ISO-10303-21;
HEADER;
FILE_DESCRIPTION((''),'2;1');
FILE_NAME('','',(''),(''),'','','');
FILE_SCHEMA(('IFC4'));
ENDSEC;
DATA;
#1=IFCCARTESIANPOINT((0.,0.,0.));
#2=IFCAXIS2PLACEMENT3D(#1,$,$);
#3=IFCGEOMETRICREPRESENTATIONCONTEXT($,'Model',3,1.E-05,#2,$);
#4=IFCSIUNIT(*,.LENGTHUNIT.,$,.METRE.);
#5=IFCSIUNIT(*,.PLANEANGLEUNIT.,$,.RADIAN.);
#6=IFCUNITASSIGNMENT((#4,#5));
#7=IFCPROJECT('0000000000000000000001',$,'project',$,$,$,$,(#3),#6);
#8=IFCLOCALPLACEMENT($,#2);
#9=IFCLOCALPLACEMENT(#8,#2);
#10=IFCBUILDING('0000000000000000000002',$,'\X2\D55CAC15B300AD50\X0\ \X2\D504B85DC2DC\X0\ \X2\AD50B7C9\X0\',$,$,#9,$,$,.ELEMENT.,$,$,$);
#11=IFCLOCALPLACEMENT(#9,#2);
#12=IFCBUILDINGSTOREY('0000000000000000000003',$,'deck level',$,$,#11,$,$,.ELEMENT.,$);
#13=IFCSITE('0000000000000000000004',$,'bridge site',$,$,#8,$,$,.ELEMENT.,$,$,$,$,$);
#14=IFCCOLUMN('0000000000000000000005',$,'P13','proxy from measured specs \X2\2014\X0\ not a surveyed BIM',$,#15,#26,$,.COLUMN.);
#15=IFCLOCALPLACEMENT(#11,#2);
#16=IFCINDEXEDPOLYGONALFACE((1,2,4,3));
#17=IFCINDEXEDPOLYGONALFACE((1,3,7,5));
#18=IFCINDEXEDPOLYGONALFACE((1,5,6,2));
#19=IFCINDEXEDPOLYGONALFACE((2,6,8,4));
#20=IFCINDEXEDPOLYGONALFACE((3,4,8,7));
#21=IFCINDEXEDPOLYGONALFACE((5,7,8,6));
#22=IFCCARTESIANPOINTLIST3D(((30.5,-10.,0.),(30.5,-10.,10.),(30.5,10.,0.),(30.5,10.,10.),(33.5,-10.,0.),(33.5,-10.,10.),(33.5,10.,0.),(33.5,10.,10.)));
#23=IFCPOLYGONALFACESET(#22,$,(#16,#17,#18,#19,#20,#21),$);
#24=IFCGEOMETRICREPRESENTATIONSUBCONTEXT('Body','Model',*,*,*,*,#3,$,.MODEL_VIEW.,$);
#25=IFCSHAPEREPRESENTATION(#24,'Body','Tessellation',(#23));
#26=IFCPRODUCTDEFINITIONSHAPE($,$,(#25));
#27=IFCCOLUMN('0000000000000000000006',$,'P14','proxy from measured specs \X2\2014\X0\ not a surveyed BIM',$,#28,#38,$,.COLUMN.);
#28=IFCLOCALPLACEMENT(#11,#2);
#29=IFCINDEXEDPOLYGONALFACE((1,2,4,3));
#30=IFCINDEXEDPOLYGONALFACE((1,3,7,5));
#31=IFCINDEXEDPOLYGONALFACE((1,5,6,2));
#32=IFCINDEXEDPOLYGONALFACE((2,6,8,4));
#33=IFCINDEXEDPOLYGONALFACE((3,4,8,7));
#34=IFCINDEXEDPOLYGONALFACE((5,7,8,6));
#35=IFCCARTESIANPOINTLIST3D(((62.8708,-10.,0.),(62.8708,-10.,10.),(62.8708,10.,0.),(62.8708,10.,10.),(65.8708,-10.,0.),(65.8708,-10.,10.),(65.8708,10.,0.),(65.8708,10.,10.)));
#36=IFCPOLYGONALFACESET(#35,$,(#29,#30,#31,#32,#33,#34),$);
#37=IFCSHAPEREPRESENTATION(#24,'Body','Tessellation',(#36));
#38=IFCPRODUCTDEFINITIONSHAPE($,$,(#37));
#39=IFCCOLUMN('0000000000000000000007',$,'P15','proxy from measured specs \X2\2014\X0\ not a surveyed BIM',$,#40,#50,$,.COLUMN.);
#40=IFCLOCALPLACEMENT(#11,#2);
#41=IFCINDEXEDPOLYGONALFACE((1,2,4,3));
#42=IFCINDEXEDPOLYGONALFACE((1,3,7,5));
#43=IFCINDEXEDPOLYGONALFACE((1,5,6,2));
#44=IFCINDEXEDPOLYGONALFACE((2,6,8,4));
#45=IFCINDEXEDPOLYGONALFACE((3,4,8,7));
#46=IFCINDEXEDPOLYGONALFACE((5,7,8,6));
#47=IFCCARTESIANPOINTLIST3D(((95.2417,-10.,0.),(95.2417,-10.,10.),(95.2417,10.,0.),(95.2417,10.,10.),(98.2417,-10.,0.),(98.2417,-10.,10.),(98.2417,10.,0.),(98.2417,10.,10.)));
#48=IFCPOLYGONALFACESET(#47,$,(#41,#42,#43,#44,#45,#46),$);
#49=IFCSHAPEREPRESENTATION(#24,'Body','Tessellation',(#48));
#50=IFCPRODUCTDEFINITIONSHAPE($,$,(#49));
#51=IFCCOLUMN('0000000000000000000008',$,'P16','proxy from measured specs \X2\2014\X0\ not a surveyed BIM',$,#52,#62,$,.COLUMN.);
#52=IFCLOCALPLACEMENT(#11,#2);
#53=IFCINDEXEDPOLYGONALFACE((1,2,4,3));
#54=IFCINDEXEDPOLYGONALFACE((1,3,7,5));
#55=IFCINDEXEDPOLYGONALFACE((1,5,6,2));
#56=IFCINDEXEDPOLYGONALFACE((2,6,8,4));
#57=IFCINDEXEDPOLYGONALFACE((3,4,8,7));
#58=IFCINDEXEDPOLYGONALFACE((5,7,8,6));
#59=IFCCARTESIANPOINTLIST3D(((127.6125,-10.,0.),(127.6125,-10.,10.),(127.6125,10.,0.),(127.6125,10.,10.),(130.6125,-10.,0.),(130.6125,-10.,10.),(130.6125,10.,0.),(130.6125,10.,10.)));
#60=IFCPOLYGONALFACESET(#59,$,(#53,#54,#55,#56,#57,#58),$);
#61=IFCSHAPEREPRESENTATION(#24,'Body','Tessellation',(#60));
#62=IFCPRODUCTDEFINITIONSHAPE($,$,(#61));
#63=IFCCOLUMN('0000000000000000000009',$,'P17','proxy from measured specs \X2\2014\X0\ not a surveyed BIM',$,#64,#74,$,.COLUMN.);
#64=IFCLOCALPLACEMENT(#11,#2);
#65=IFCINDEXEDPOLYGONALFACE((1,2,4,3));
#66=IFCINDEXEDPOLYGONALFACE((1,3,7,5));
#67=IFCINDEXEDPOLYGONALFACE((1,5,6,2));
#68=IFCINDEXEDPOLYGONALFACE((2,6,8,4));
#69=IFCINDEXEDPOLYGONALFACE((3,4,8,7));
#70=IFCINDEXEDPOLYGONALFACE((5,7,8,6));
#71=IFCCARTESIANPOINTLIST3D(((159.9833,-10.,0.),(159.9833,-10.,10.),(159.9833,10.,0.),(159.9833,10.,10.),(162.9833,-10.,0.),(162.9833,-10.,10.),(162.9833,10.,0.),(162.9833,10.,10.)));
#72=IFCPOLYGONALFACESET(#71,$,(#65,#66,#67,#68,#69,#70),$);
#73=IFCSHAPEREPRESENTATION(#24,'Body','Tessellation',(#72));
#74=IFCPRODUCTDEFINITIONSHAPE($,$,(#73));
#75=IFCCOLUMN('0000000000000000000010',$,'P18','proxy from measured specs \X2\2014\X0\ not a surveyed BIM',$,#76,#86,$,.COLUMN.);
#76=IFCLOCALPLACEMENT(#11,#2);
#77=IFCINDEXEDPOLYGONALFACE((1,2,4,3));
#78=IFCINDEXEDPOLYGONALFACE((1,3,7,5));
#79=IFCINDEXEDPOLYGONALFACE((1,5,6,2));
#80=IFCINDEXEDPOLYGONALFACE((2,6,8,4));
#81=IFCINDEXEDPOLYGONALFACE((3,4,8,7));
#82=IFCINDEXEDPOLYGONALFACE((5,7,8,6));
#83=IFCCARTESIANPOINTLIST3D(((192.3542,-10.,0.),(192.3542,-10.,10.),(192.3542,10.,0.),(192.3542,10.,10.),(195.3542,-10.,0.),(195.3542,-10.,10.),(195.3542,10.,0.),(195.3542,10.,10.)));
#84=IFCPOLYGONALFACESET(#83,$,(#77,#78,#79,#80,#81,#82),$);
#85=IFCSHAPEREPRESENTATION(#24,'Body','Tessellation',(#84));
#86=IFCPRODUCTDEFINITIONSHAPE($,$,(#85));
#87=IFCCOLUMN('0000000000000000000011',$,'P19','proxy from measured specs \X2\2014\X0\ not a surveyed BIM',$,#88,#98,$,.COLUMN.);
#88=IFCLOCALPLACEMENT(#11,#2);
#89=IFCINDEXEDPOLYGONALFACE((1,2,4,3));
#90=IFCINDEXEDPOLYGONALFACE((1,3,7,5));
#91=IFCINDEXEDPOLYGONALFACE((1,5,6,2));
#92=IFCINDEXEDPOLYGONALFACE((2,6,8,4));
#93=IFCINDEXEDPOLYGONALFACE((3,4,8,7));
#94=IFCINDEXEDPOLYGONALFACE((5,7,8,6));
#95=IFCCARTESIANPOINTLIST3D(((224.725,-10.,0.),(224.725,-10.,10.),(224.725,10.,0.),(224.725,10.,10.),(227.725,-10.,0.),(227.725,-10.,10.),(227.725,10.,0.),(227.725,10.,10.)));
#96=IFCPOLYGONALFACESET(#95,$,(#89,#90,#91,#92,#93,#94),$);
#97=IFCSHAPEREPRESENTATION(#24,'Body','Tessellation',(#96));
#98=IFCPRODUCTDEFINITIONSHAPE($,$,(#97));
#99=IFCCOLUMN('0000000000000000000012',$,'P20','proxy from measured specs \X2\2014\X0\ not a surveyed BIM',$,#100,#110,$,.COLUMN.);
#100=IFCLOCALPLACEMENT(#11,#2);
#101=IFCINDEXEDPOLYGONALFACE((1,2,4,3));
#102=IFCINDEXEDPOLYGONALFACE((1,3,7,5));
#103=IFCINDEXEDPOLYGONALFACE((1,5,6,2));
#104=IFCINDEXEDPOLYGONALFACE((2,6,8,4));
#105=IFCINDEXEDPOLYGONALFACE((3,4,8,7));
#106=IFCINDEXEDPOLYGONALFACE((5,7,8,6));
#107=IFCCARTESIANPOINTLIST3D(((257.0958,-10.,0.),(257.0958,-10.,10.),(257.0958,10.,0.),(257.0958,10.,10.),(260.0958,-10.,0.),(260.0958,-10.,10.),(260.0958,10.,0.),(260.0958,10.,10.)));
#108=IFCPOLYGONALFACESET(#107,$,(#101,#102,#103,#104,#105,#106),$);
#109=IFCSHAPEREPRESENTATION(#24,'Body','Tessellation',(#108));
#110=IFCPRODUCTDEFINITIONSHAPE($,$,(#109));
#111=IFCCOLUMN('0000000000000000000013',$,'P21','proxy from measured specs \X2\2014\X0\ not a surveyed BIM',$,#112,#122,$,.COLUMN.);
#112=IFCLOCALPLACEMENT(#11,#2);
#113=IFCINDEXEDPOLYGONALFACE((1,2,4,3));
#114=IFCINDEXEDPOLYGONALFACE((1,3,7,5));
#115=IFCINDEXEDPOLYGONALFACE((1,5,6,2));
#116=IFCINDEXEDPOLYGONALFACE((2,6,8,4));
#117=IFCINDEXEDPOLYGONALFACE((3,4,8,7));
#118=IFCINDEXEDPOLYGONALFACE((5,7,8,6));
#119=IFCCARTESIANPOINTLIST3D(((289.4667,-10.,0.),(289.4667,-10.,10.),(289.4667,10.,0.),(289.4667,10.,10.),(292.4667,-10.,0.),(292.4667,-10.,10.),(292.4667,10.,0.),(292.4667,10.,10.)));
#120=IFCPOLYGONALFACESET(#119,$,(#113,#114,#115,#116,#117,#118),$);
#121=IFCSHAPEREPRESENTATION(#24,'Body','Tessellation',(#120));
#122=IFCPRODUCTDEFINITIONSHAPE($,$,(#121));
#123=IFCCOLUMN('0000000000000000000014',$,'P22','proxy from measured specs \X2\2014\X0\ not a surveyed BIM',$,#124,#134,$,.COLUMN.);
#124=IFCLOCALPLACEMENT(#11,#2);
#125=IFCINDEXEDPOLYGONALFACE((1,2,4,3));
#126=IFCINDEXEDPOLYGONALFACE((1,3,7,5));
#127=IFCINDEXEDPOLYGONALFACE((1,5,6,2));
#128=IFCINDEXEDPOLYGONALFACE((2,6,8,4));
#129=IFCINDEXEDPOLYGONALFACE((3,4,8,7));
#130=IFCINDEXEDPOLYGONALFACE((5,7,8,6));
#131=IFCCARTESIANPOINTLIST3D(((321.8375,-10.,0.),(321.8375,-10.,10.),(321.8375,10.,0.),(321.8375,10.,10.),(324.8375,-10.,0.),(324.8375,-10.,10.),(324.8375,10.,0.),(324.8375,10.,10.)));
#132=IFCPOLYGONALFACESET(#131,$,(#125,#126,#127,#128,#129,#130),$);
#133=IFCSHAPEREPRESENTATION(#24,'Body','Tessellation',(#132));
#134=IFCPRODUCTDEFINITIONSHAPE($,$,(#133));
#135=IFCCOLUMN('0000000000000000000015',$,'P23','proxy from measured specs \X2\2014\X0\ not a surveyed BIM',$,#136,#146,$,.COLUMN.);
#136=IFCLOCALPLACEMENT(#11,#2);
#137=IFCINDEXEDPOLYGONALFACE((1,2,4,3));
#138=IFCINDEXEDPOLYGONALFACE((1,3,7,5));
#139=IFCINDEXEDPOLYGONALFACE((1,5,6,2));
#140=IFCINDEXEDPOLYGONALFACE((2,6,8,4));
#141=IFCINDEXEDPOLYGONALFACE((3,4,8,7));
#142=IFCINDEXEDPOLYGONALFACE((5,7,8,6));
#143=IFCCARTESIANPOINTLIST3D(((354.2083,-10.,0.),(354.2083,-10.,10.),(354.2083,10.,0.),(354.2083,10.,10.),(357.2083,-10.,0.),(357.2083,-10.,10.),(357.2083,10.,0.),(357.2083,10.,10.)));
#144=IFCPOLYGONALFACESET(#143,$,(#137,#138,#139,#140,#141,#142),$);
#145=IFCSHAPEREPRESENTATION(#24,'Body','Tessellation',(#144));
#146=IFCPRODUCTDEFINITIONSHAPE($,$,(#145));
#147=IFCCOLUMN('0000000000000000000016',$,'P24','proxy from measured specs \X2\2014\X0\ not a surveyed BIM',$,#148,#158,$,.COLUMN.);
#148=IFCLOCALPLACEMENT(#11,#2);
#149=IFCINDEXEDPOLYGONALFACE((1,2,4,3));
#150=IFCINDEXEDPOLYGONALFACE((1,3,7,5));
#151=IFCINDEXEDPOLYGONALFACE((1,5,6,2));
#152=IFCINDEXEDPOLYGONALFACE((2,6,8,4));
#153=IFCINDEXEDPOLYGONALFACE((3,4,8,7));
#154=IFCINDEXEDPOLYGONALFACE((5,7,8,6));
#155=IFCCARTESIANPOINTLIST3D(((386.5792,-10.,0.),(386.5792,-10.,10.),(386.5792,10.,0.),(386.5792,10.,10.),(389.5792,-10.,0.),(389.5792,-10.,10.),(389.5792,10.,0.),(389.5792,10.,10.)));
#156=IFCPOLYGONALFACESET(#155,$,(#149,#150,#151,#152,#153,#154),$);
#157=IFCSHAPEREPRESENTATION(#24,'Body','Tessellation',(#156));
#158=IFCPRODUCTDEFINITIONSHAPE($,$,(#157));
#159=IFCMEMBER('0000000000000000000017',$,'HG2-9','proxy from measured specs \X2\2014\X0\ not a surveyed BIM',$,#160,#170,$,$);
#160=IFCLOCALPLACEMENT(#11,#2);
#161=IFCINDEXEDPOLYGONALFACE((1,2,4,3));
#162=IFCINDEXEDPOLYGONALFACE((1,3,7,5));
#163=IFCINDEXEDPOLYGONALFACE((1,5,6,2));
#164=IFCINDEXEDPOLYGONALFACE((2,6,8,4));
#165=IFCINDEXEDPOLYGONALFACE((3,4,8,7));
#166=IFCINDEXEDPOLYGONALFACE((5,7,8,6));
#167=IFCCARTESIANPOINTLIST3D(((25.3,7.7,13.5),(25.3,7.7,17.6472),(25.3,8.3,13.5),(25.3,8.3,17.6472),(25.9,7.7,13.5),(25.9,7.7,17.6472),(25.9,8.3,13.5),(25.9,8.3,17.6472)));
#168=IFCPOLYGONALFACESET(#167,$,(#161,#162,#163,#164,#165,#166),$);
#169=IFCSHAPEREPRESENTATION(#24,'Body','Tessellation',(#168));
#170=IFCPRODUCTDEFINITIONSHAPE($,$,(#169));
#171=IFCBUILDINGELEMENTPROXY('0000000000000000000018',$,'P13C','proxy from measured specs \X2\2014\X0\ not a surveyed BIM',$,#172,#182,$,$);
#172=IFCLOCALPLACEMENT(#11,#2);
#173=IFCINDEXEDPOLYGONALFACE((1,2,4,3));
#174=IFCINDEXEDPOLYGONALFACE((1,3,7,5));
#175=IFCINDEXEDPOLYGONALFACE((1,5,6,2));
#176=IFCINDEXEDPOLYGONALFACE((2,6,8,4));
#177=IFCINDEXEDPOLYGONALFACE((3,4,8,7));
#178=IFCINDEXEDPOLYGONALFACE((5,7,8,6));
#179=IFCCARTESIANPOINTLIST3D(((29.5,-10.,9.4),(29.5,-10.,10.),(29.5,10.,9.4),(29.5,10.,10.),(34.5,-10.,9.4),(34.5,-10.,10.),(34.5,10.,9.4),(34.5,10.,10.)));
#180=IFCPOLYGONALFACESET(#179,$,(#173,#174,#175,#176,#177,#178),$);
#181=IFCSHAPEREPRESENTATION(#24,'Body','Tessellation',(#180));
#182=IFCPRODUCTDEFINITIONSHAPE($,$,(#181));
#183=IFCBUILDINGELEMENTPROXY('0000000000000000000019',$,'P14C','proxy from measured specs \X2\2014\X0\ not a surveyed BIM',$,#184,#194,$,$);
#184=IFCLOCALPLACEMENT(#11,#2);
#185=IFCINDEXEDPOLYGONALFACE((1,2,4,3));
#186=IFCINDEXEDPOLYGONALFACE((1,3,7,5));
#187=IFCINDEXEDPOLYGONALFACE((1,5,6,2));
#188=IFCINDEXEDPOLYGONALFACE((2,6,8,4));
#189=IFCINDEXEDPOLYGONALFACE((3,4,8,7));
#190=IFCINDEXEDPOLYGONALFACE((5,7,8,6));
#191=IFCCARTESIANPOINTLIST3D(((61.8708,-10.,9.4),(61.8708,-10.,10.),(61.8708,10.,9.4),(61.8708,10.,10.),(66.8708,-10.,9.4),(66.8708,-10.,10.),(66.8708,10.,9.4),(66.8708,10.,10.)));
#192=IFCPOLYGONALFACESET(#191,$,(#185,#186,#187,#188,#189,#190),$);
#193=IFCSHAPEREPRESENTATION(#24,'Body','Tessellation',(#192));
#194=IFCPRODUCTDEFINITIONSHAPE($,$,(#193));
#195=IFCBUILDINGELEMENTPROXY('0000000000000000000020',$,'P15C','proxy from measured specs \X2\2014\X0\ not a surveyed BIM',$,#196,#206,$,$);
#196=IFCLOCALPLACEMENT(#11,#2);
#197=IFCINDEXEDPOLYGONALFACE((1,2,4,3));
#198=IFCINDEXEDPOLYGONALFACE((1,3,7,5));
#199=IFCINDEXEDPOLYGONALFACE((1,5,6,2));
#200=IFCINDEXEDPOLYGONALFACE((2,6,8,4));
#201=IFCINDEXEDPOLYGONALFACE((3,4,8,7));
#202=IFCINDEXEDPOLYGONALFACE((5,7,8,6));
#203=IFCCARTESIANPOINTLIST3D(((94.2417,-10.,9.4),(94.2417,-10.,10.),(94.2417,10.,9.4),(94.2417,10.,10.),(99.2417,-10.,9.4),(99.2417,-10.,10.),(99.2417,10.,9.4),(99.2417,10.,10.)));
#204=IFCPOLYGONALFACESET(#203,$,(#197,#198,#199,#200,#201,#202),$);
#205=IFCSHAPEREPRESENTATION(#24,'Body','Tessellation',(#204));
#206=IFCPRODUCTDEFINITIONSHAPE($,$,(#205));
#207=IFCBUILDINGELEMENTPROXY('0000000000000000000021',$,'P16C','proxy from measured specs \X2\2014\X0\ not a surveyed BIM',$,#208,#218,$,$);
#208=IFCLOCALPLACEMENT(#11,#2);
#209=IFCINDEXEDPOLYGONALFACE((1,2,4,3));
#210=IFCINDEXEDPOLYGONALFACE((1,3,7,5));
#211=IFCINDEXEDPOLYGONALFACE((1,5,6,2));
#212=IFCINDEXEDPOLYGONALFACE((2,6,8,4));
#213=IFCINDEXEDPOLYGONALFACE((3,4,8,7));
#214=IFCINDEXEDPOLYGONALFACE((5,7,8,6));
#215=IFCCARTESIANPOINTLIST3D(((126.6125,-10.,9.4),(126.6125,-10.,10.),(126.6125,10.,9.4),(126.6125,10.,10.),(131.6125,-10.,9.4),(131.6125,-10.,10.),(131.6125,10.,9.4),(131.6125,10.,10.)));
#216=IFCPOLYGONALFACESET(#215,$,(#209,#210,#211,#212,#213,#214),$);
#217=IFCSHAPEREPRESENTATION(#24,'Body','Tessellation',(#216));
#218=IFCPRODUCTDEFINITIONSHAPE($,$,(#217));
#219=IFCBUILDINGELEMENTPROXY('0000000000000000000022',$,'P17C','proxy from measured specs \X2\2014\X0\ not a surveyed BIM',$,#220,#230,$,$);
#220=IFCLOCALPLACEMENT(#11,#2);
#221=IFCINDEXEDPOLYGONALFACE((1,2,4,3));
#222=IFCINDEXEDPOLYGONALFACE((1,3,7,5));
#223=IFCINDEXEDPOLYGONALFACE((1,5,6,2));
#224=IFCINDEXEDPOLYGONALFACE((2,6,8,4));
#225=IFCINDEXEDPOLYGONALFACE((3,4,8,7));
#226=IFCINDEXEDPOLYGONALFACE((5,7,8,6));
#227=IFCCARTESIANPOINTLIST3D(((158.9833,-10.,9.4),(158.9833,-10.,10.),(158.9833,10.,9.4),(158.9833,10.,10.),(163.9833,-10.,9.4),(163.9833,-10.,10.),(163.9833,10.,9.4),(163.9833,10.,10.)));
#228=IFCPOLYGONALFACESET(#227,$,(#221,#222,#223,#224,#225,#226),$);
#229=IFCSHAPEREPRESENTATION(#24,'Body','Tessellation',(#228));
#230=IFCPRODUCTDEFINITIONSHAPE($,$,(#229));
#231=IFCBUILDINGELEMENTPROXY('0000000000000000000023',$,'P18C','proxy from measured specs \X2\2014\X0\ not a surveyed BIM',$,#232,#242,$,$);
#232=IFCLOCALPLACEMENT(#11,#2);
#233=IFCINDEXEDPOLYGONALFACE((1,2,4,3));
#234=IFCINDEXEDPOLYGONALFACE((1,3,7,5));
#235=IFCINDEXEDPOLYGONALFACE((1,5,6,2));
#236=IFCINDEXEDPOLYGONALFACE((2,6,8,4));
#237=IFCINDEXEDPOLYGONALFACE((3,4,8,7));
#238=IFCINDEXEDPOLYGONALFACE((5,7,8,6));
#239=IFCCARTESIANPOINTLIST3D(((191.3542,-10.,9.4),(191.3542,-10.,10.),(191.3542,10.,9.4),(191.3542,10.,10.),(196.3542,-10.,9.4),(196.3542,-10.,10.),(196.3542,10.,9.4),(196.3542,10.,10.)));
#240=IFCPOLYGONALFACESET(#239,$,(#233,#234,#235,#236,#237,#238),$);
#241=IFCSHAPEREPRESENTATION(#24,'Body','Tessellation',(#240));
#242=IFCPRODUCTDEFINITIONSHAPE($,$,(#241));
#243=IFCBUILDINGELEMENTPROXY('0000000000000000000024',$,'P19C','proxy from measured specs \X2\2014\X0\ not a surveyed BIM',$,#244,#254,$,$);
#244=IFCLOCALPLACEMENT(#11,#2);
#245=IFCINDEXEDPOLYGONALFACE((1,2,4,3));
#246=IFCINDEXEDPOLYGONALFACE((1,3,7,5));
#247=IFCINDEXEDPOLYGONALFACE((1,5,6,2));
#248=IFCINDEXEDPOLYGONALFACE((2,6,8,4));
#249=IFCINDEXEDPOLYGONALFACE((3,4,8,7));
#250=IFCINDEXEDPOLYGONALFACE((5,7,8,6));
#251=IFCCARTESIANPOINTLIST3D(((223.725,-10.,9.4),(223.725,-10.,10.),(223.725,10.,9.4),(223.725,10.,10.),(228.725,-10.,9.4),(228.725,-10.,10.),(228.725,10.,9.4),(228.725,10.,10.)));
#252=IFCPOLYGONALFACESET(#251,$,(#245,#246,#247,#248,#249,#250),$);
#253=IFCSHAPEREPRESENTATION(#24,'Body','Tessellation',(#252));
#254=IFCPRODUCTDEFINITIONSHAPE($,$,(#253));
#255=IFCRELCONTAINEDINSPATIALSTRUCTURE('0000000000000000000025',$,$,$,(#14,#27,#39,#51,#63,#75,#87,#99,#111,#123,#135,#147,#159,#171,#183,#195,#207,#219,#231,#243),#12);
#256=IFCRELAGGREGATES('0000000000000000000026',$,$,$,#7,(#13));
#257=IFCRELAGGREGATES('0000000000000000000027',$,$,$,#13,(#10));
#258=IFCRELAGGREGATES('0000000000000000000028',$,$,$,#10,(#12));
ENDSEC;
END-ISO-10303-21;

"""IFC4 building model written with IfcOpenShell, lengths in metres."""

from ifc_helpers import new_model, si_unit, frame, origin, origin_2d, place, context, subcontext, project, spatial, rectangle, extrude, element, save


model = new_model("IFC4")

# Units and contexts
model_context = context("Model", 3, precision=1e-05, world=origin())
body_context = subcontext(model_context, "Body", "Model", "MODEL_VIEW")
ifc_project = project(units=[si_unit("LENGTHUNIT", "METRE"), si_unit("PLANEANGLEUNIT", "RADIAN")], contexts=[model_context])

# Site, building, storey
site_placement = place(None, origin())
site = spatial("IfcSite", under=ifc_project, at=site_placement, Name="bridge site", CompositionType="ELEMENT")
building_placement = place(site_placement, origin())
building = spatial("IfcBuilding", under=site, at=building_placement, Name="한강대교 프록시 교량", CompositionType="ELEMENT")
storey_placement = place(building_placement, origin())
storey = spatial("IfcBuildingStorey", under=building, at=storey_placement, Name="deck level", CompositionType="ELEMENT")

# Columns
for number, where, name in (
    (1, (32.0, 0.0, 0.0), "P13"),
    (2, (64.3708, 0.0, 0.0), "P14"),
    (3, (96.7417, 0.0, 0.0), "P15"),
    (4, (129.1125, 0.0, 0.0), "P16"),
    (5, (161.4833, 0.0, 0.0), "P17"),
    (6, (193.8542, 0.0, 0.0), "P18"),
    (7, (226.225, 0.0, 0.0), "P19"),
    (8, (258.5958, 0.0, 0.0), "P20"),
    (9, (290.9667, 0.0, 0.0), "P21"),
    (10, (323.3375, 0.0, 0.0), "P22"),
    (11, (355.7083, 0.0, 0.0), "P23"),
    (12, (388.0792, 0.0, 0.0), "P24"),
):
    element("IfcColumn", number, at=place(storey_placement, frame(where)), inside=storey, Name=name, Description="proxy from measured specs — not a surveyed BIM", PredefinedType="COLUMN", context=body_context, shape_type="SweptSolid", body=[
        extrude(rectangle(XDim=3.0, YDim=20.0, at=origin_2d()), origin(), (0.0, 0.0, 1.0), 10.0),
    ])

# Member
member_placement = place(storey_placement, frame((25.6, 8.0, 13.5)))
element("IfcMember", 13, at=member_placement, inside=storey, Name="HG2-9", Description="proxy from measured specs — not a surveyed BIM", context=body_context, shape_type="SweptSolid", body=[
    extrude(rectangle(XDim=0.6, YDim=0.6, at=origin_2d()), origin(), (0.0, 0.0, 1.0), 4.1472),
])

# Building element proxies
for number, where, name in (
    (14, (32.0, 0.0, 9.4), "P13C"),
    (15, (64.3708, 0.0, 9.4), "P14C"),
    (16, (96.7417, 0.0, 9.4), "P15C"),
    (17, (129.1125, 0.0, 9.4), "P16C"),
    (18, (161.4833, 0.0, 9.4), "P17C"),
    (19, (193.8542, 0.0, 9.4), "P18C"),
    (20, (226.225, 0.0, 9.4), "P19C"),
):
    element("IfcBuildingElementProxy", number, at=place(storey_placement, frame(where)), inside=storey, Name=name, Description="proxy from measured specs — not a surveyed BIM", context=body_context, shape_type="SweptSolid", body=[
        extrude(rectangle(XDim=5.0, YDim=20.0, at=origin_2d()), origin(), (0.0, 0.0, 1.0), 0.6),
    ])

save(model, "model.ifc")
